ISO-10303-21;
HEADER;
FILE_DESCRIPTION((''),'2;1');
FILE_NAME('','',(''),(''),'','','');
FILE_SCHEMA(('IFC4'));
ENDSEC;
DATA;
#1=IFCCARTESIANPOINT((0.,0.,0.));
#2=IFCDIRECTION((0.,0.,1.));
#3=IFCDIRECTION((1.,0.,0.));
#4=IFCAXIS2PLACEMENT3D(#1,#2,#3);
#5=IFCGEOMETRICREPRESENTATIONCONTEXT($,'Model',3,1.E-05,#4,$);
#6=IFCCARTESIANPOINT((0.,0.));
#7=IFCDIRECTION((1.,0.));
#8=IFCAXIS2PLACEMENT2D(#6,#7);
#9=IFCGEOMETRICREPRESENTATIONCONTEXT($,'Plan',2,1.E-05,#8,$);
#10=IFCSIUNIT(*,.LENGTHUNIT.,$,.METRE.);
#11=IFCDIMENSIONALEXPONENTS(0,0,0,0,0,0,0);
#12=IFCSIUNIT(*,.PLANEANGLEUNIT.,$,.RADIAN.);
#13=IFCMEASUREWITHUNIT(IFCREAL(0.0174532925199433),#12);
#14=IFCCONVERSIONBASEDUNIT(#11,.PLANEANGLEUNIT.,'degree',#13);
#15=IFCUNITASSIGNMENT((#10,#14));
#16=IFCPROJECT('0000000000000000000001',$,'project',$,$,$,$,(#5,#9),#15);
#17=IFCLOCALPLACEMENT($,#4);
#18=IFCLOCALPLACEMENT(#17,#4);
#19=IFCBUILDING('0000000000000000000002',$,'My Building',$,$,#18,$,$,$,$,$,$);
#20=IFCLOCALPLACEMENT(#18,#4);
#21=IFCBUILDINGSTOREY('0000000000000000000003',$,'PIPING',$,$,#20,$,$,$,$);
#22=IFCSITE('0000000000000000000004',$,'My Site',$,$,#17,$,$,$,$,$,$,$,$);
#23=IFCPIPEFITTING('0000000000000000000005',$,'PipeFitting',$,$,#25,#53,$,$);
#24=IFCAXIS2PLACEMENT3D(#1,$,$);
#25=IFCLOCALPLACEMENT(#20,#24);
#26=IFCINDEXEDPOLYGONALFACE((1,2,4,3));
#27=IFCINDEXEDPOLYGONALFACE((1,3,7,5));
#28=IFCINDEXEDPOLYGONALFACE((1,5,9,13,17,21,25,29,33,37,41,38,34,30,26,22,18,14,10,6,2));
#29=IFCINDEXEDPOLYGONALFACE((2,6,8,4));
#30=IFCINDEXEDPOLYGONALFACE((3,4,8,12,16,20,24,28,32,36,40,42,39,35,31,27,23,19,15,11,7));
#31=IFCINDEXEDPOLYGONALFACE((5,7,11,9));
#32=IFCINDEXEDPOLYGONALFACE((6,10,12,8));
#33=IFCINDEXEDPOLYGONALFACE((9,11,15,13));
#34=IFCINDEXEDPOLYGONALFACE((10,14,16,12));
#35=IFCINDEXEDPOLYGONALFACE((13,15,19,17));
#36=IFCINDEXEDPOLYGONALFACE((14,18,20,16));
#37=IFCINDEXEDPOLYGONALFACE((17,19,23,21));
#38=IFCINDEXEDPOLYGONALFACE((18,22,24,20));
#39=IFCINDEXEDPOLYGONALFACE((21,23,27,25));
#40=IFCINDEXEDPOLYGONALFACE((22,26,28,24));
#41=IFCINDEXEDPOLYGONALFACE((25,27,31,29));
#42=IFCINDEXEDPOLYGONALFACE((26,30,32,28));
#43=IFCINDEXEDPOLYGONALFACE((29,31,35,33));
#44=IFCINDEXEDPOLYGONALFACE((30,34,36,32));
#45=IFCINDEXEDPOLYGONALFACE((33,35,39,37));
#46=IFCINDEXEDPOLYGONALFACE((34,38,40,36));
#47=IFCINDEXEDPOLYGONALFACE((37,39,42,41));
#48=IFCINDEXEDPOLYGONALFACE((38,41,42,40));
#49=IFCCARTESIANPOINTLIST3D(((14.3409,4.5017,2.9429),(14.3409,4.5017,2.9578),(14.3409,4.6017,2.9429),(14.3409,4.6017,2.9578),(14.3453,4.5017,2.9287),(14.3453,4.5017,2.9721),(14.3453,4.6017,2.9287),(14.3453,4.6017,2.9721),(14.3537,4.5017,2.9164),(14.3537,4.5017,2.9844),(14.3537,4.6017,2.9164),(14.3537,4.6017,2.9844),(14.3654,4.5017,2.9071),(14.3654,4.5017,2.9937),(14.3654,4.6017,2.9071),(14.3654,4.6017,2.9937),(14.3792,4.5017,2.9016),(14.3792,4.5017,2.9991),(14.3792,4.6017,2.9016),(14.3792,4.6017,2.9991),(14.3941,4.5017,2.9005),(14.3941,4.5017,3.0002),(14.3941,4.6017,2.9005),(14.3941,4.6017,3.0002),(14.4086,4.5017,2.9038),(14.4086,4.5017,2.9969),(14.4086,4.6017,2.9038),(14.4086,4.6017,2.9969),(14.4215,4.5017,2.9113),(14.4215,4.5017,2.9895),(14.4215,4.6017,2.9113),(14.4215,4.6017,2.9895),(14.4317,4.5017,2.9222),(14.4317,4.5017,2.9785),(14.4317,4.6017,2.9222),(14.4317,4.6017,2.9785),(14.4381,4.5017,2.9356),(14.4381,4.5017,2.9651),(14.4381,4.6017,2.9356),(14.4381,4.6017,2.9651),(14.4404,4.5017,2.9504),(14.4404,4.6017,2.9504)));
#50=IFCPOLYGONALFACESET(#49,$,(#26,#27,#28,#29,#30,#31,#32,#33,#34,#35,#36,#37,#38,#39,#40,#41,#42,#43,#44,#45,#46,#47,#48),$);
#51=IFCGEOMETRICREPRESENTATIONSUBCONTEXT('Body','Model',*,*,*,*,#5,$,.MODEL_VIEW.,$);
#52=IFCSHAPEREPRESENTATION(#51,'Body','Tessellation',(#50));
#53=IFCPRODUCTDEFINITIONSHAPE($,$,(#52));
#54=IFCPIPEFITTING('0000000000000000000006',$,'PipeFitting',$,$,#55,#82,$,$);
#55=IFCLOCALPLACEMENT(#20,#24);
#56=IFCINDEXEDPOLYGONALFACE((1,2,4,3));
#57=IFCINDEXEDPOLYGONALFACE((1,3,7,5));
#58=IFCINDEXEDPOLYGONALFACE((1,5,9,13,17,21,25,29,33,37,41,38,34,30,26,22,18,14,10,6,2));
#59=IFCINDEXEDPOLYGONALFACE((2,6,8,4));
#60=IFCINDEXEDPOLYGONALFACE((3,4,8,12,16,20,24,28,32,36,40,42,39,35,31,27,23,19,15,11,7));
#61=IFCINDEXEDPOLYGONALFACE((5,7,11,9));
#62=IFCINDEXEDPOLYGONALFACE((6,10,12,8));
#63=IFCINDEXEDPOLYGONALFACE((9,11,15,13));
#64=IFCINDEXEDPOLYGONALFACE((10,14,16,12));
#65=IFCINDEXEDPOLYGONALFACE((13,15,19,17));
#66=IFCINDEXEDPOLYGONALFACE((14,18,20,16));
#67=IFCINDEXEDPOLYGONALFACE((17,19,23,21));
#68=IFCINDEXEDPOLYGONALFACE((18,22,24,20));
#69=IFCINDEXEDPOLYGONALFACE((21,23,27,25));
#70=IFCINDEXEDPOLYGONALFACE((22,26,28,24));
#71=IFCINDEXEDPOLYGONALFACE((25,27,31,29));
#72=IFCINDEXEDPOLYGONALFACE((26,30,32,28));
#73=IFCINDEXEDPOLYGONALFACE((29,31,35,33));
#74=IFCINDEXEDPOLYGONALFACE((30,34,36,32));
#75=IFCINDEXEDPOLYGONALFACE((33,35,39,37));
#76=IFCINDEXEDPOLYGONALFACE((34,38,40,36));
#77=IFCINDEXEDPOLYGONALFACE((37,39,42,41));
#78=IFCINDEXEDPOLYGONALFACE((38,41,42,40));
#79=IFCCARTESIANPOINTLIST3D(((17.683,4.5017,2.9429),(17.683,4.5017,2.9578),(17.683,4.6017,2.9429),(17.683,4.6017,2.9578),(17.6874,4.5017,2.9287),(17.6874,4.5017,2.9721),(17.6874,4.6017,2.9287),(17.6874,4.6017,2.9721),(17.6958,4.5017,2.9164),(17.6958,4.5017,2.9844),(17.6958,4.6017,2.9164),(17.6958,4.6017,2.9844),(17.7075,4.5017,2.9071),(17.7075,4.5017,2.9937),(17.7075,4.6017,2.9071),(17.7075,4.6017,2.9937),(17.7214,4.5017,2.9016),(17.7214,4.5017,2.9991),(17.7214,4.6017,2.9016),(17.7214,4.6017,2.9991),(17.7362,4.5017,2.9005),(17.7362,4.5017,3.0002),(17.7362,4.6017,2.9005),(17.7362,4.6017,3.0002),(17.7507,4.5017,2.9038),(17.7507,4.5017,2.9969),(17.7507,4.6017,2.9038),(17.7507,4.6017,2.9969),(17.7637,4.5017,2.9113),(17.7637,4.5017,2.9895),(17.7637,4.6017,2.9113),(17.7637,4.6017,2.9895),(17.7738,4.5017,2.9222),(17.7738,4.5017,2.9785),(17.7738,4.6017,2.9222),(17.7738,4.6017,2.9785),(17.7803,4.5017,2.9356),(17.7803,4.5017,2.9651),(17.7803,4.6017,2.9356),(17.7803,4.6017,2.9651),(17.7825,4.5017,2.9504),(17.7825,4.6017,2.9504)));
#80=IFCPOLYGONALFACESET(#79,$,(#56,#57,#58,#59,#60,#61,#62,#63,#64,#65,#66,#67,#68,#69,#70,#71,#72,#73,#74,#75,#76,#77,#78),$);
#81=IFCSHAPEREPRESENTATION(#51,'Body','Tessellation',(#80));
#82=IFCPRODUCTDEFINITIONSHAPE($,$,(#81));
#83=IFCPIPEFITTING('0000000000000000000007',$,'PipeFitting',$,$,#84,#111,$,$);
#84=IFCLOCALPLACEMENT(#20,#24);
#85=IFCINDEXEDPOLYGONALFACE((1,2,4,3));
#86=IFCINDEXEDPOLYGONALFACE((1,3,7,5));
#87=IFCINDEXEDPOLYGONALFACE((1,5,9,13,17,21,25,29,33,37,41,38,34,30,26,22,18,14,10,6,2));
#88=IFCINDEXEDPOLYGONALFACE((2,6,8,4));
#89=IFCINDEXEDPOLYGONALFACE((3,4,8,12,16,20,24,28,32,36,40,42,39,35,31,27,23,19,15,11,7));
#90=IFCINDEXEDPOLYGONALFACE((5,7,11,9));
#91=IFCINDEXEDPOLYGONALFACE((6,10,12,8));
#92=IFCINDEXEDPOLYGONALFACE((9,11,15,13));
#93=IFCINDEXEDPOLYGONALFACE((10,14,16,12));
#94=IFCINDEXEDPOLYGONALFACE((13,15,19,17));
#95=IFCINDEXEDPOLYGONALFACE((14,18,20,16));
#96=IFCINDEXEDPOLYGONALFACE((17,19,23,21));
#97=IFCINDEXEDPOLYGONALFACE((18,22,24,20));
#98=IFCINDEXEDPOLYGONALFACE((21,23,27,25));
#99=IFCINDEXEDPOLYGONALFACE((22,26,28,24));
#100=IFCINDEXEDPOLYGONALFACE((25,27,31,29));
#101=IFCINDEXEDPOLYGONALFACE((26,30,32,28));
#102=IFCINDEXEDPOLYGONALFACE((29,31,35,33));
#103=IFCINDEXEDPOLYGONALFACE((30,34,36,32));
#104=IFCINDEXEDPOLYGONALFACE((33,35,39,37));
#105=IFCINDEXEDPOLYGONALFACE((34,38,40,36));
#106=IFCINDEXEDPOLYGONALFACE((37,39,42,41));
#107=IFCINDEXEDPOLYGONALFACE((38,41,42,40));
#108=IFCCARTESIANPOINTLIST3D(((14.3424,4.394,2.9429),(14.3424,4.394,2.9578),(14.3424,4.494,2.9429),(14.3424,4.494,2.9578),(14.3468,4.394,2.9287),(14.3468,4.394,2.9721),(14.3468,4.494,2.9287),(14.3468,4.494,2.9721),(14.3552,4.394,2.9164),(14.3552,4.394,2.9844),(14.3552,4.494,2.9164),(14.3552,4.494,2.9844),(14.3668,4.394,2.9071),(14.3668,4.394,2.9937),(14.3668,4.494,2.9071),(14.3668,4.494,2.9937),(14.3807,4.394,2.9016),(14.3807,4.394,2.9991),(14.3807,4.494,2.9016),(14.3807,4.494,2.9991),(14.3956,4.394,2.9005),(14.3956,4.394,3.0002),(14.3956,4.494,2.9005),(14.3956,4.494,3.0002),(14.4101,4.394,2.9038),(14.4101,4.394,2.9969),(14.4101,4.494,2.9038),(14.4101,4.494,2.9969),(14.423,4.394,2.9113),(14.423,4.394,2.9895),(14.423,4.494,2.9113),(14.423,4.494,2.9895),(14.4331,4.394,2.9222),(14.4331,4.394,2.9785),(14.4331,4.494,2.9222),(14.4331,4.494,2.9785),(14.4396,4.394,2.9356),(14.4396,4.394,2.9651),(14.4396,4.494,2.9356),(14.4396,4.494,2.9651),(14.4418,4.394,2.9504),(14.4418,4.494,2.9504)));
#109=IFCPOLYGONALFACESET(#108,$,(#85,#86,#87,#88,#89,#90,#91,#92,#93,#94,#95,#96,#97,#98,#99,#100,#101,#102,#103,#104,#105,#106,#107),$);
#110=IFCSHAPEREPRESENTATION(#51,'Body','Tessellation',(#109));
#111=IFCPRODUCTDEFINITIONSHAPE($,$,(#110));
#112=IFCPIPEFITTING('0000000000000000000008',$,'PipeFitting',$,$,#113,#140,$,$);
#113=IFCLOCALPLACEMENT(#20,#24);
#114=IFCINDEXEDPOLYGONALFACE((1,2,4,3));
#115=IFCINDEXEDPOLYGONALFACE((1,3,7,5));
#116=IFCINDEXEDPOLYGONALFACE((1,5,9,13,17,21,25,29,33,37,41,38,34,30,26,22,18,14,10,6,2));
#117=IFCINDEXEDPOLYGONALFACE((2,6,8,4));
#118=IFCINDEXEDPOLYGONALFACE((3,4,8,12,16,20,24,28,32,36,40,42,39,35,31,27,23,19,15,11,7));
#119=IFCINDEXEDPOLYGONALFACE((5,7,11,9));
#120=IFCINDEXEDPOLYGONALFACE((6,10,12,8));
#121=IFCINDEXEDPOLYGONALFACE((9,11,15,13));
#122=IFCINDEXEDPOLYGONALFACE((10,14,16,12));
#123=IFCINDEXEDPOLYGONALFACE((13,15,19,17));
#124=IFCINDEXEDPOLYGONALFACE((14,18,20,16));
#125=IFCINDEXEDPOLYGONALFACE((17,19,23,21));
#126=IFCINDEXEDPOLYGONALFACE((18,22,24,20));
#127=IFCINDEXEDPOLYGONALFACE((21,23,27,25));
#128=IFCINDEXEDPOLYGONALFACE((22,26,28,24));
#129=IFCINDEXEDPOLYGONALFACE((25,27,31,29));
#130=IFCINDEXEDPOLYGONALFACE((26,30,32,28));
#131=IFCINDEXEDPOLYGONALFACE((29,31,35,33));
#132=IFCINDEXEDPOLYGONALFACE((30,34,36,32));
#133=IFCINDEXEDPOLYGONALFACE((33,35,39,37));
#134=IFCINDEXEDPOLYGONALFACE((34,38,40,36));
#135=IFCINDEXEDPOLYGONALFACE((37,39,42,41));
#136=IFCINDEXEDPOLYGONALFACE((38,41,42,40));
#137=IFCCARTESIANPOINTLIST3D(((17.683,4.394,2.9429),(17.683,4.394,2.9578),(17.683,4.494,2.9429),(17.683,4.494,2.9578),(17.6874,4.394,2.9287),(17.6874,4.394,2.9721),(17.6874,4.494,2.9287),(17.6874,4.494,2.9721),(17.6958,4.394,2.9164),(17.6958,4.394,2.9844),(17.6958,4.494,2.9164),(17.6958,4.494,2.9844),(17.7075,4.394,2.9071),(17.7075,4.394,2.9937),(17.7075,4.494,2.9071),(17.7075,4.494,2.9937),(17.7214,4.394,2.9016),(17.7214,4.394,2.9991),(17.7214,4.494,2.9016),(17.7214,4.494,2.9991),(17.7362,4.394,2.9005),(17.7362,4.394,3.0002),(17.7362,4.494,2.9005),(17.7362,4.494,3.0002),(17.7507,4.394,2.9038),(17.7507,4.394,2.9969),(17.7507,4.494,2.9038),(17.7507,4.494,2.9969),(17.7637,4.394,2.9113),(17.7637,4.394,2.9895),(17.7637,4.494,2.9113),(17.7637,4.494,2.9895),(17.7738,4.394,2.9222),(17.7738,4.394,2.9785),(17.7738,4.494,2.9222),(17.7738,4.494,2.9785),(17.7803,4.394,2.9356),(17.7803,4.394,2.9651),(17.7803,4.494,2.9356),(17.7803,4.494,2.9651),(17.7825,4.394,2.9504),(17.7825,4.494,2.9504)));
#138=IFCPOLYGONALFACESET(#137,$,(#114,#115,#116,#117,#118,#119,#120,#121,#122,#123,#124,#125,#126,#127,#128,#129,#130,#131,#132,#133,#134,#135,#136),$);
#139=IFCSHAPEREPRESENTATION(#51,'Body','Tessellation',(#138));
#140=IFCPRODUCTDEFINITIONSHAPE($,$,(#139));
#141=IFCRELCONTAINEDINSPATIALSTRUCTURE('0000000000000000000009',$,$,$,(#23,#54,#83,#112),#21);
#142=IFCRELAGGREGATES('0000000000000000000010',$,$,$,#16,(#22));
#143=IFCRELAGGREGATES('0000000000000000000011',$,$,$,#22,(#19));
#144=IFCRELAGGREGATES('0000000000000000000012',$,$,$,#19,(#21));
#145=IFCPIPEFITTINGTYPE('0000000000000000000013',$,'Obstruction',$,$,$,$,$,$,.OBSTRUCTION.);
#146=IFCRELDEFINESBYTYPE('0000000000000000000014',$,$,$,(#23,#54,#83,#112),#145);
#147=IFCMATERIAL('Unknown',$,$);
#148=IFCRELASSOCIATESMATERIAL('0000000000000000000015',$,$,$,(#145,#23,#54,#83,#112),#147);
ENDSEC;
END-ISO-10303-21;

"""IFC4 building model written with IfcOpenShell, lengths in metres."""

from ifc_helpers import new_model, entity, si_unit, converted_unit, frame, origin_with_axes, origin_2d_with_axis, place, context, subcontext, project, spatial, circle, extrude, material, material_profile, profile_set, profile_usage, type_object, element, save


model = new_model("IFC4")

# Units and contexts
model_context = context("Model", 3, precision=1e-05, world=origin_with_axes())
plan_context = context("Plan", 2, precision=1e-05, world=origin_2d_with_axis())
body_context = subcontext(model_context, "Body", "Model", "MODEL_VIEW")
ifc_project = project(units=[si_unit("LENGTHUNIT", "METRE"), converted_unit("PLANEANGLEUNIT", "degree", entity("IfcReal", 0.0174532925199433), si_unit("PLANEANGLEUNIT", "RADIAN"), dimensions=[0, 0, 0, 0, 0, 0, 0])], contexts=[model_context, plan_context])

# Site, building, storey
site_placement = place(None, origin_with_axes())
site = spatial("IfcSite", under=ifc_project, at=site_placement, Name="My Site")
building_placement = place(site_placement, origin_with_axes())
building = spatial("IfcBuilding", under=site, at=building_placement, Name="My Building")
storey_placement = place(building_placement, origin_with_axes())
storey = spatial("IfcBuildingStorey", under=building, at=storey_placement, Name="PIPING")

# Shared definitions
ifc_material = material(Name="Unknown")

# Pipe fittings
ifc_material_profile_1 = material_profile(ifc_material, circle(Radius=0.05))
ifc_profile_set_1 = profile_set([ifc_material_profile_1])
ifc_profile_usage_1 = profile_usage(ifc_profile_set_1, cardinal=5)
pipe_fitting_type_1 = type_object("IfcPipeFittingType", Name="Obstruction", PredefinedType="OBSTRUCTION", material=ifc_profile_set_1)
pipe_fitting_1_placement = place(storey_placement, frame((14.3904, 4.5017, 2.9504), z_axis=(0.0, 1.0, 0.0), x_axis=(1.0, 0.0, 0.0)))
element("IfcPipeFitting", 1, at=pipe_fitting_1_placement, inside=storey, type_object=pipe_fitting_type_1, material=ifc_profile_usage_1, Name="PipeFitting", context=body_context, shape_type="SweptSolid", body=[
    extrude(circle(Radius=0.05), origin_with_axes(), (0.0, 0.0, 1.0), 0.1),
])
ifc_profile_usage_2 = profile_usage(ifc_profile_set_1, cardinal=5)
pipe_fitting_2_placement = place(storey_placement, frame((17.7325, 4.5017, 2.9504), z_axis=(0.0, 1.0, 0.0), x_axis=(1.0, 0.0, 0.0)))
element("IfcPipeFitting", 2, at=pipe_fitting_2_placement, inside=storey, type_object=pipe_fitting_type_1, material=ifc_profile_usage_2, Name="PipeFitting", context=body_context, shape_type="SweptSolid", body=[
    extrude(circle(Radius=0.05), origin_with_axes(), (0.0, 0.0, 1.0), 0.1),
])
ifc_profile_usage_3 = profile_usage(ifc_profile_set_1, cardinal=5)
pipe_fitting_3_placement = place(storey_placement, frame((14.3918, 4.394, 2.9504), z_axis=(0.0, 1.0, 0.0), x_axis=(1.0, 0.0, 0.0)))
element("IfcPipeFitting", 3, at=pipe_fitting_3_placement, inside=storey, type_object=pipe_fitting_type_1, material=ifc_profile_usage_3, Name="PipeFitting", context=body_context, shape_type="SweptSolid", body=[
    extrude(circle(Radius=0.05), origin_with_axes(), (0.0, 0.0, 1.0), 0.1),
])
ifc_profile_usage_4 = profile_usage(ifc_profile_set_1, cardinal=5)
pipe_fitting_4_placement = place(storey_placement, frame((17.7325, 4.394, 2.9504), z_axis=(0.0, 1.0, 0.0), x_axis=(1.0, 0.0, 0.0)))
element("IfcPipeFitting", 4, at=pipe_fitting_4_placement, inside=storey, type_object=pipe_fitting_type_1, material=ifc_profile_usage_4, Name="PipeFitting", context=body_context, shape_type="SweptSolid", body=[
    extrude(circle(Radius=0.05), origin_with_axes(), (0.0, 0.0, 1.0), 0.1),
])

save(model, "model.ifc")
